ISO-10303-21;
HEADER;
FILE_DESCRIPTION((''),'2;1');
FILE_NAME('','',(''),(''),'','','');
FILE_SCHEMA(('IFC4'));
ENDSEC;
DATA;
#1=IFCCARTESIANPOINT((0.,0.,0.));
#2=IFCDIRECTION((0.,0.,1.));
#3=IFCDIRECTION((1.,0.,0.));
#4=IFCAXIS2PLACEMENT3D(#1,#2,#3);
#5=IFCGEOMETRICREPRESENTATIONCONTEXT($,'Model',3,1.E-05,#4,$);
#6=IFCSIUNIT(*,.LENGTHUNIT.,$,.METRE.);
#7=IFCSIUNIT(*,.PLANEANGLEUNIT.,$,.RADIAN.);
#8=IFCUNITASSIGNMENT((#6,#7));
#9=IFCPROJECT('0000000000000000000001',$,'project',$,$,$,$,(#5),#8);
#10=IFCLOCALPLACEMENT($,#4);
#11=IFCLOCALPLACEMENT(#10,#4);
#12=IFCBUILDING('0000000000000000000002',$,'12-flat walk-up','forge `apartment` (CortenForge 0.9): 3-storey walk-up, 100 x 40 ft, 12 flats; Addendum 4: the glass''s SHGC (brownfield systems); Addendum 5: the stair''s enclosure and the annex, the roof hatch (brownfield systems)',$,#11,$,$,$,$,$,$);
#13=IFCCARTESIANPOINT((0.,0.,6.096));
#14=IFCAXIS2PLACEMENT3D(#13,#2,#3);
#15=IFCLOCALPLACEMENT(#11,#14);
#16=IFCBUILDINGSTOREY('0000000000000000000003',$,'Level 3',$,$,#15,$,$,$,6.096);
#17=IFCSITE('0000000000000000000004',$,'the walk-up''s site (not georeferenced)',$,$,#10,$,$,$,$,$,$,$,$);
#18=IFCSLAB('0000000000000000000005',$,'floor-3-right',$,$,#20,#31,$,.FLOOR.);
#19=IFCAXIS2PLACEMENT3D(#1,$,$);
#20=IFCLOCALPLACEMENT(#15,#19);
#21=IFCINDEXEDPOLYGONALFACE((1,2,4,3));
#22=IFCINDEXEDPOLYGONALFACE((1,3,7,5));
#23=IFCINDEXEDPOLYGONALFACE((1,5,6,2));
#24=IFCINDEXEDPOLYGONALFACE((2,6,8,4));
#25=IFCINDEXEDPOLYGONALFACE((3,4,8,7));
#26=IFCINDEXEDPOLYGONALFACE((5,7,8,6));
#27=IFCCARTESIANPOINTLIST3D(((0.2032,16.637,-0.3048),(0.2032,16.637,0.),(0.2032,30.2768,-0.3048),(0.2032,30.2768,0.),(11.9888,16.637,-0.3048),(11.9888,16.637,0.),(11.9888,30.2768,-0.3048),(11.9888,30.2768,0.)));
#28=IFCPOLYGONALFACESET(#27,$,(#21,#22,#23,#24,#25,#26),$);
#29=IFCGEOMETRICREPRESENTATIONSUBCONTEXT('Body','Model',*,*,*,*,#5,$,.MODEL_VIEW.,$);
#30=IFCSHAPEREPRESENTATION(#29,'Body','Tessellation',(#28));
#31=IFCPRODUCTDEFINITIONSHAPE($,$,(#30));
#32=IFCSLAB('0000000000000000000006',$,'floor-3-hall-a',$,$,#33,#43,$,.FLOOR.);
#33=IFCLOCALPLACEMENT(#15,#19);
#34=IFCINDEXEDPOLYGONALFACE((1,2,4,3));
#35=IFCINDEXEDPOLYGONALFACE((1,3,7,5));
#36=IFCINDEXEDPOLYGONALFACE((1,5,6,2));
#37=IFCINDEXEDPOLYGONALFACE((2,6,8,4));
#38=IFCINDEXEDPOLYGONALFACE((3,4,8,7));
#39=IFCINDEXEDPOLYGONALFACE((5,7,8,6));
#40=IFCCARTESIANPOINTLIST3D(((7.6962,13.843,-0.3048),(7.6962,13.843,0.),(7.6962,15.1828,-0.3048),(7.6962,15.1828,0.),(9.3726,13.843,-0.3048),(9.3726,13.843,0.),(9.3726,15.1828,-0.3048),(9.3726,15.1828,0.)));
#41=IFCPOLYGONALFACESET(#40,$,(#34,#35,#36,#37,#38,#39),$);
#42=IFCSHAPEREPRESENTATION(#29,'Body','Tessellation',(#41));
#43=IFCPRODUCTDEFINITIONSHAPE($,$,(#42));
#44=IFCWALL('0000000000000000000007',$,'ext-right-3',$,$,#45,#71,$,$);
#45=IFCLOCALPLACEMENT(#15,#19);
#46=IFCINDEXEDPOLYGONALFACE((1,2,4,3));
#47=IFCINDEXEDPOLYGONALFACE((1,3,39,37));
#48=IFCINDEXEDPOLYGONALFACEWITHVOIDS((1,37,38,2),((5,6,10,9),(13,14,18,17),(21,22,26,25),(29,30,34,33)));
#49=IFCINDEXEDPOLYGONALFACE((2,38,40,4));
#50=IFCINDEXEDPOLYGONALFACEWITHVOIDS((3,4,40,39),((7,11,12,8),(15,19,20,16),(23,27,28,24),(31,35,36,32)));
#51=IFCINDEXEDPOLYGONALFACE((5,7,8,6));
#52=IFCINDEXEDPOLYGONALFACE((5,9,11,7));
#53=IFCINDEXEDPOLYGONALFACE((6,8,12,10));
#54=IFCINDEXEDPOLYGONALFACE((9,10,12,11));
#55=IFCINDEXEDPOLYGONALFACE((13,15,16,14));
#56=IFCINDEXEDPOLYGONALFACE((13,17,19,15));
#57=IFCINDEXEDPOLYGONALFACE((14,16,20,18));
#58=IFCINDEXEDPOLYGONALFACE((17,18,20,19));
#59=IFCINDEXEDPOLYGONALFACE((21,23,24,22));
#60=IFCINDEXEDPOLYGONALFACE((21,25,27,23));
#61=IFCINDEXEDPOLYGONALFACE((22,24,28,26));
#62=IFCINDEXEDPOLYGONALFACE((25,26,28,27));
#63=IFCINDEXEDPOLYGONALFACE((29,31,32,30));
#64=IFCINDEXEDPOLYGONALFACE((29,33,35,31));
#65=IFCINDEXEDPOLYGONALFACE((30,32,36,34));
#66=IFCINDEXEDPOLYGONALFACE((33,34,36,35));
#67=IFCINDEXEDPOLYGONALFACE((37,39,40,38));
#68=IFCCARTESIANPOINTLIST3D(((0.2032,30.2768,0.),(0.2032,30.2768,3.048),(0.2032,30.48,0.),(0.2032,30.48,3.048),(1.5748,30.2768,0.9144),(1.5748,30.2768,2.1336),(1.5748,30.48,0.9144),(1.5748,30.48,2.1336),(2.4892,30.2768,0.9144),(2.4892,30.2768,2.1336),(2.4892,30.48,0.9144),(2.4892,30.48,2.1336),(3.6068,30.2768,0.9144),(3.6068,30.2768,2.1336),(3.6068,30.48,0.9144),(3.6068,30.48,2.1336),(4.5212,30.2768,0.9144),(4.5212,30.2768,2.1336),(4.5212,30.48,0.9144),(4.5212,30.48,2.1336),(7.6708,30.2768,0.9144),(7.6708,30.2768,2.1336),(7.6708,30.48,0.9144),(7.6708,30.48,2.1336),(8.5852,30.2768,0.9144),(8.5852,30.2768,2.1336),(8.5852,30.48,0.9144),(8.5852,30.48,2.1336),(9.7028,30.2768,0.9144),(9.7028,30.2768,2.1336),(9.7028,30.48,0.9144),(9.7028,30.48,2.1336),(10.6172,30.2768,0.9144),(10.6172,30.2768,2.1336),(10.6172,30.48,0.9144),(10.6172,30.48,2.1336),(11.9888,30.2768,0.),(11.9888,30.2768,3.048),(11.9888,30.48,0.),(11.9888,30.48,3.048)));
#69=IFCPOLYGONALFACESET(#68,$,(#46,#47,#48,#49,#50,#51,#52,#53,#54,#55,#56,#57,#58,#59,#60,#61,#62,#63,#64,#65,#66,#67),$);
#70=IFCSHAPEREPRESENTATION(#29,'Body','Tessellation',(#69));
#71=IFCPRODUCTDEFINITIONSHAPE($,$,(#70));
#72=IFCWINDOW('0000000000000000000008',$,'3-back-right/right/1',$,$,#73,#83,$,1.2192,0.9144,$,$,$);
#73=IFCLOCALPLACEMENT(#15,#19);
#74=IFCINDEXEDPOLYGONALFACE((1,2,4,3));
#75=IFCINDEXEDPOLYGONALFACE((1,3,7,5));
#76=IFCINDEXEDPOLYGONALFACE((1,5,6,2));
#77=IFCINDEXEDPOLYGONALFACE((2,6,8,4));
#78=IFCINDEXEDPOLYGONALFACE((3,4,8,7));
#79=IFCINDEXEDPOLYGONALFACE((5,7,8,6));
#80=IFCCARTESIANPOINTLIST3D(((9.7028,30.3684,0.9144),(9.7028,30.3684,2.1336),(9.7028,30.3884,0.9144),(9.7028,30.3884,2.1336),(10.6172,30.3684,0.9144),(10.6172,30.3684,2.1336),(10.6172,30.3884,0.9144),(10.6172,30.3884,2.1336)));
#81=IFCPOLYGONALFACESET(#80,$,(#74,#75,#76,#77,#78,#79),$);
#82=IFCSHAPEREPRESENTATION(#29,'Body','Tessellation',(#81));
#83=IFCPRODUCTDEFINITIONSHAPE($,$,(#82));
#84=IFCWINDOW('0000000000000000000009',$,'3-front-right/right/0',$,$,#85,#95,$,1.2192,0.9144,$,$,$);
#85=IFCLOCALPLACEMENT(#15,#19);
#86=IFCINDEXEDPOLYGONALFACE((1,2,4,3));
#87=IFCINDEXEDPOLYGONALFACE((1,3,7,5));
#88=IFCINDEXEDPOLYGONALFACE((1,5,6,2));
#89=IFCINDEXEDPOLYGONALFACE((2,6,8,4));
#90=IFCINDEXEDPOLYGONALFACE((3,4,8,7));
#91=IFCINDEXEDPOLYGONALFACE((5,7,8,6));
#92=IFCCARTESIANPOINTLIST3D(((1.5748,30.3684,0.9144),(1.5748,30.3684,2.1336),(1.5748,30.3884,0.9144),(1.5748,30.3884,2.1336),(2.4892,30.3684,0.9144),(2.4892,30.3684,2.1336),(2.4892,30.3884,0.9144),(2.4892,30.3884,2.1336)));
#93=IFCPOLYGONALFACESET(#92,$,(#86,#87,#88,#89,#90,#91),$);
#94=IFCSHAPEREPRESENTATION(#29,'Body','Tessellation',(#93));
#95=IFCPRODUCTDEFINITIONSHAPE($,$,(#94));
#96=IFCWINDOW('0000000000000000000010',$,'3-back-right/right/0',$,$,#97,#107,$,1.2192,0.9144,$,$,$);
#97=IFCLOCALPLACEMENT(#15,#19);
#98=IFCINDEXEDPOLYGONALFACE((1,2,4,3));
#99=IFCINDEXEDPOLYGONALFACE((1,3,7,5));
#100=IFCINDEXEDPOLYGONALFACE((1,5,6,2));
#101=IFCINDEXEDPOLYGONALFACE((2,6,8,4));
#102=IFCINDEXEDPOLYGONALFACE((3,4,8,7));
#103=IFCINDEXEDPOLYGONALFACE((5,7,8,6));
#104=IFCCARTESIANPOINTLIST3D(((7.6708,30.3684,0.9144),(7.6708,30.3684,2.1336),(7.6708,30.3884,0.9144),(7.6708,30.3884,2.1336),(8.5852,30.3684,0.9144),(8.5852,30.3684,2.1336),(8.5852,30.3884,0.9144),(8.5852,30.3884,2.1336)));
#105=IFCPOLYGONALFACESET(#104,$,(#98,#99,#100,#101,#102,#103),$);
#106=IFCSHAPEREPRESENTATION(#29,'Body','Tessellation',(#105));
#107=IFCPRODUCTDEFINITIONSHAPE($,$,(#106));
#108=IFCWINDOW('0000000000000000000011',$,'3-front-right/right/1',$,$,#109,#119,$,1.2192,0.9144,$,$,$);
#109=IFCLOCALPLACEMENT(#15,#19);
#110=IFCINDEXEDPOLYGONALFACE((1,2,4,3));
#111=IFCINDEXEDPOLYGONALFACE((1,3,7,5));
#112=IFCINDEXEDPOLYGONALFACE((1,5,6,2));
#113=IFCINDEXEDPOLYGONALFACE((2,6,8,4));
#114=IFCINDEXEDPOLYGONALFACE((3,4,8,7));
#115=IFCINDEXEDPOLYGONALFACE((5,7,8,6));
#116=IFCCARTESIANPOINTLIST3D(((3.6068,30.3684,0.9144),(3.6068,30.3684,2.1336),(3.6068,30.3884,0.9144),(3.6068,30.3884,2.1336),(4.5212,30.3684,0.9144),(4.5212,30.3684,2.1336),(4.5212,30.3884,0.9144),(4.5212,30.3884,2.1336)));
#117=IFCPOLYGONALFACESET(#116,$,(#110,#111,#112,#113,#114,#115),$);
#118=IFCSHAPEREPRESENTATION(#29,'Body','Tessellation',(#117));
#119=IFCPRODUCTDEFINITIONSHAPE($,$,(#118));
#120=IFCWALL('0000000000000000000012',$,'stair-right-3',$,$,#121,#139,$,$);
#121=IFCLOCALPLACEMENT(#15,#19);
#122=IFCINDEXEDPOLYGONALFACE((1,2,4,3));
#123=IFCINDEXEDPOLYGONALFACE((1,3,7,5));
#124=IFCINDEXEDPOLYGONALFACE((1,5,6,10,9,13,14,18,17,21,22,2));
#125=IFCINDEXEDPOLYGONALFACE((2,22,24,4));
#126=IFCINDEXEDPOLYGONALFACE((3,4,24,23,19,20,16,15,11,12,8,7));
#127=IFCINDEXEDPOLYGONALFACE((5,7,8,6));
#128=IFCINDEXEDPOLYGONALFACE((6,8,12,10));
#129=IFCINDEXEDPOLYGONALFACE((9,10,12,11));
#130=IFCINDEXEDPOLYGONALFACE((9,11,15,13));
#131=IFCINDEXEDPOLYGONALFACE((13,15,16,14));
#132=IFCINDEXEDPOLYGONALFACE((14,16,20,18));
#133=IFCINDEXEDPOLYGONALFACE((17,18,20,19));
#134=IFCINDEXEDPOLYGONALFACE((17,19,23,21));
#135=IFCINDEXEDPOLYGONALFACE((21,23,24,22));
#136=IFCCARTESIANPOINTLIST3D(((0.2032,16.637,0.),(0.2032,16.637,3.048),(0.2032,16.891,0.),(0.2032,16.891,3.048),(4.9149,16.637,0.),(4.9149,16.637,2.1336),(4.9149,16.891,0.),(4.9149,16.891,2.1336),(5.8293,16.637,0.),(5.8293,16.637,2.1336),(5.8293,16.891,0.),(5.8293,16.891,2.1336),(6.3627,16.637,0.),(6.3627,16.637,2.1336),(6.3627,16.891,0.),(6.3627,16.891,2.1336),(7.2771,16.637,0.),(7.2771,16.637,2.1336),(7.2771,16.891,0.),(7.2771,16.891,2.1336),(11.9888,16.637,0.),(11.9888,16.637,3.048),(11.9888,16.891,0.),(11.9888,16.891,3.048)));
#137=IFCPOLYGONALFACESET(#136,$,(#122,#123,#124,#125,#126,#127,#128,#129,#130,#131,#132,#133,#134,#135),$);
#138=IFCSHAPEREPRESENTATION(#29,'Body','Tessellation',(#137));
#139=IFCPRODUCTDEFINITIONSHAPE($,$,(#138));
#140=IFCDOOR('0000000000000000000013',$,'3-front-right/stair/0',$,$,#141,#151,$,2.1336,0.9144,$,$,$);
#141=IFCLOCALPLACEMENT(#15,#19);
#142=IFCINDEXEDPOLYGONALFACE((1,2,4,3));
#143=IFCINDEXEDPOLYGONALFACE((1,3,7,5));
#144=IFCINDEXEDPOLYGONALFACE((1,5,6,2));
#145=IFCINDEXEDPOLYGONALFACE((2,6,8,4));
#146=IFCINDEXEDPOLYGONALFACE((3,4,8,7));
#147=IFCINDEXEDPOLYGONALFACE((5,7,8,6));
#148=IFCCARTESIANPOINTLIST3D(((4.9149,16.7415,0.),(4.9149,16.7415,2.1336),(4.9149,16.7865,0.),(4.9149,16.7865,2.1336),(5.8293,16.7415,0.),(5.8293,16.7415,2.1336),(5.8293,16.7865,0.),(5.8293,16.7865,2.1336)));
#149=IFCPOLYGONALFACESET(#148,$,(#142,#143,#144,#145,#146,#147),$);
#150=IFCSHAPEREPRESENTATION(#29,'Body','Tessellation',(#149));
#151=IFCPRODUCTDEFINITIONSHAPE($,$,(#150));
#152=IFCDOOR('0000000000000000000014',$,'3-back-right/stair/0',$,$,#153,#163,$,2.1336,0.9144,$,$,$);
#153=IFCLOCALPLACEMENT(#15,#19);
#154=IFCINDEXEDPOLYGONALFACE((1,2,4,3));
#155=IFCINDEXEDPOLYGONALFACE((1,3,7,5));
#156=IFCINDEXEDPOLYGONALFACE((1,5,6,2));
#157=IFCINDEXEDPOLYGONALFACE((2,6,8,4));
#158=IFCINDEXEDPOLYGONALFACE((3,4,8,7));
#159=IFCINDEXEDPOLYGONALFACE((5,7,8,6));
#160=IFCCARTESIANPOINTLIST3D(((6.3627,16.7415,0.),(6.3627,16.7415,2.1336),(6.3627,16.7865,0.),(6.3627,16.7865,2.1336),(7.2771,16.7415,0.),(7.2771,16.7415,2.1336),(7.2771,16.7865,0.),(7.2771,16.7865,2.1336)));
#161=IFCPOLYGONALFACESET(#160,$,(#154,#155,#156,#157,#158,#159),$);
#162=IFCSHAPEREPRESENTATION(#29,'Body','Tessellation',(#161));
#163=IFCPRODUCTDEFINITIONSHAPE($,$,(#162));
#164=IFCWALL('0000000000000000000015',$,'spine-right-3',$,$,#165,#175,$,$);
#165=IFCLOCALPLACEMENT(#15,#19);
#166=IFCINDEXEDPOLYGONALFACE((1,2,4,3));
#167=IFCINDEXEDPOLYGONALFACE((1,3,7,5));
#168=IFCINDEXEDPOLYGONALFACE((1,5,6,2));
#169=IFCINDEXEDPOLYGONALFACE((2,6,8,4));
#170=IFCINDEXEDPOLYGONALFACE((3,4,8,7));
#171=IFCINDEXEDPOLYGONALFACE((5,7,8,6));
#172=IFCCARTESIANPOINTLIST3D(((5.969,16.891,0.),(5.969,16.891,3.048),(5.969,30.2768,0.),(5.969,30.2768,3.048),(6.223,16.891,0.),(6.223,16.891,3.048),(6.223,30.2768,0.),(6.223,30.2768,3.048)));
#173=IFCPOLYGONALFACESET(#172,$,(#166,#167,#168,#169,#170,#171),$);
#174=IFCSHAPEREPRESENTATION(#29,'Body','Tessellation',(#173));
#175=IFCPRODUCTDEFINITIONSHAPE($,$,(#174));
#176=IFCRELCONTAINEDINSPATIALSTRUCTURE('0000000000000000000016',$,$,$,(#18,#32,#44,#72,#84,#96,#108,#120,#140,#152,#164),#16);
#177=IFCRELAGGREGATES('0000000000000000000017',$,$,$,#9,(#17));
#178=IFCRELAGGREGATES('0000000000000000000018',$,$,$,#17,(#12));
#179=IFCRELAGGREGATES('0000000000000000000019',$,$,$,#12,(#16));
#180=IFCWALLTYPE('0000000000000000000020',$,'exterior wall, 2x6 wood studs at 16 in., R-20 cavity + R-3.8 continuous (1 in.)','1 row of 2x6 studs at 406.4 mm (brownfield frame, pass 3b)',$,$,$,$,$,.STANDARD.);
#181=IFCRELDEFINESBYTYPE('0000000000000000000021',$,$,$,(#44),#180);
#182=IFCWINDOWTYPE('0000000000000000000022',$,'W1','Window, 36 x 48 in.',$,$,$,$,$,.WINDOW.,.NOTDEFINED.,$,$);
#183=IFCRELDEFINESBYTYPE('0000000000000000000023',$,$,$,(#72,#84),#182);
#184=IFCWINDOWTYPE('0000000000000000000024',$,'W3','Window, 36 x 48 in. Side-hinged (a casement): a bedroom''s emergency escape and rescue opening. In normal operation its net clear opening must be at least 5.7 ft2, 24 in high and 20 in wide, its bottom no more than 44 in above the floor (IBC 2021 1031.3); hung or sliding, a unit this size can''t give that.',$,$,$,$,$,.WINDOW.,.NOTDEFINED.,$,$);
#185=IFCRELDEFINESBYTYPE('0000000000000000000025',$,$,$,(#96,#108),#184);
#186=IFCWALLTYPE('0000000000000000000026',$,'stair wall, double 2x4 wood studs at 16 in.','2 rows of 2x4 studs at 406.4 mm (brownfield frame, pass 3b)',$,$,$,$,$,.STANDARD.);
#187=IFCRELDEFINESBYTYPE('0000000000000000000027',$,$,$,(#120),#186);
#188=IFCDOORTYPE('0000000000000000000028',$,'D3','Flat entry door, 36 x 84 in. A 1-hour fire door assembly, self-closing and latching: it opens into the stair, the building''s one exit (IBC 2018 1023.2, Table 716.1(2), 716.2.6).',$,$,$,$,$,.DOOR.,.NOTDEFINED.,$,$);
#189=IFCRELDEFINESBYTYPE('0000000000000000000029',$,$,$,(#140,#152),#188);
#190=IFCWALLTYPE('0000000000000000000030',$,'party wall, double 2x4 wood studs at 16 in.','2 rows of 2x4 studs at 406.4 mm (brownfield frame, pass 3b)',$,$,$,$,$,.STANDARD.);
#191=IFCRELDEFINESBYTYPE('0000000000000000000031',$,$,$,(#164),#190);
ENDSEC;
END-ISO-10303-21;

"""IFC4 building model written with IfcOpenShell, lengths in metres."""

from ifc_helpers import new_model, si_unit, frame, frame_2d, origin, origin_with_axes, place, context, subcontext, project, spatial, rectangle, extrude, type_object, element, fill, save


model = new_model("IFC4")

# Units and contexts
model_context = context("Model", 3, precision=1e-05, world=origin_with_axes())
body_context = subcontext(model_context, "Body", "Model", "MODEL_VIEW")
ifc_project = project(units=[si_unit("LENGTHUNIT", "METRE"), si_unit("PLANEANGLEUNIT", "RADIAN")], contexts=[model_context])

# Site, building, storey
site_placement = place(None, origin_with_axes())
site = spatial("IfcSite", under=ifc_project, at=site_placement, Name="the walk-up's site (not georeferenced)")
building_placement = place(site_placement, origin_with_axes())
building = spatial("IfcBuilding", under=site, at=building_placement, Name="12-flat walk-up", Description="forge `apartment` (CortenForge 0.9): 3-storey walk-up, 100 x 40 ft, 12 flats; Addendum 4: the glass's SHGC (brownfield systems); Addendum 5: the stair's enclosure and the annex, the roof hatch (brownfield systems)")
storey_placement = place(building_placement, frame((0.0, 0.0, 6.096), z_axis=(0.0, 0.0, 1.0), x_axis=(1.0, 0.0, 0.0)))
storey = spatial("IfcBuildingStorey", under=building, at=storey_placement, Name="Level 3", Elevation=6.096)

# Slabs
slab_1_placement = place(storey_placement, frame((0.2032, 16.637, -0.3048), z_axis=(0.0, 0.0, 1.0), x_axis=(1.0, 0.0, 0.0)))
element("IfcSlab", 1, at=slab_1_placement, inside=storey, Name="floor-3-right", PredefinedType="FLOOR", context=body_context, shape_type="SweptSolid", body=[
    extrude(rectangle(XDim=11.7856, YDim=13.6398, at=frame_2d((5.8928, 6.8199))), origin(), (0.0, 0.0, 1.0), 0.3048),
])
slab_2_placement = place(storey_placement, frame((7.6962, 13.843, -0.3048), z_axis=(0.0, 0.0, 1.0), x_axis=(1.0, 0.0, 0.0)))
element("IfcSlab", 2, at=slab_2_placement, inside=storey, Name="floor-3-hall-a", PredefinedType="FLOOR", context=body_context, shape_type="SweptSolid", body=[
    extrude(rectangle(XDim=1.6764, YDim=1.3399, at=frame_2d((0.8382, 0.6699))), origin(), (0.0, 0.0, 1.0), 0.3048),
])

# Wall, openings, windows
wall_type_1 = type_object("IfcWallType", Name="exterior wall, 2x6 wood studs at 16 in., R-20 cavity + R-3.8 continuous (1 in.)", Description="1 row of 2x6 studs at 406.4 mm (brownfield frame, pass 3b)", PredefinedType="STANDARD")
wall_1_placement = place(storey_placement, frame((0.2032, 30.2768, 0.0), z_axis=(0.0, 0.0, 1.0), x_axis=(1.0, 0.0, 0.0)))
wall_1 = element("IfcWall", 3, at=wall_1_placement, inside=storey, type_object=wall_type_1, Name="ext-right-3", context=body_context, shape_type="SweptSolid", body=[
    extrude(rectangle(XDim=11.7856, YDim=0.2032, at=frame_2d((5.8928, 0.1016))), origin(), (0.0, 0.0, 1.0), 3.048),
])
opening_1_placement = place(wall_1_placement, frame((8.382, 0.2032, 0.9144), z_axis=(0.0, 0.0, 1.0), x_axis=(-1.0, 0.0, 0.0)))
opening_1 = element("IfcOpeningElement", 4, at=opening_1_placement, cuts=wall_1, PredefinedType="OPENING", context=body_context, shape_type="SweptSolid", body=[
    extrude(rectangle(XDim=0.9144, YDim=0.2032, at=frame_2d((0.4572, 0.1016))), origin(), (0.0, 0.0, 1.0), 1.2192),
])
opening_2_placement = place(wall_1_placement, frame((10.414, 0.2032, 0.9144), z_axis=(0.0, 0.0, 1.0), x_axis=(-1.0, 0.0, 0.0)))
opening_2 = element("IfcOpeningElement", 5, at=opening_2_placement, cuts=wall_1, PredefinedType="OPENING", context=body_context, shape_type="SweptSolid", body=[
    extrude(rectangle(XDim=0.9144, YDim=0.2032, at=frame_2d((0.4572, 0.1016))), origin(), (0.0, 0.0, 1.0), 1.2192),
])
opening_3_placement = place(wall_1_placement, frame((2.286, 0.2032, 0.9144), z_axis=(0.0, 0.0, 1.0), x_axis=(-1.0, 0.0, 0.0)))
opening_3 = element("IfcOpeningElement", 6, at=opening_3_placement, cuts=wall_1, PredefinedType="OPENING", context=body_context, shape_type="SweptSolid", body=[
    extrude(rectangle(XDim=0.9144, YDim=0.2032, at=frame_2d((0.4572, 0.1016))), origin(), (0.0, 0.0, 1.0), 1.2192),
])
opening_4_placement = place(wall_1_placement, frame((4.318, 0.2032, 0.9144), z_axis=(0.0, 0.0, 1.0), x_axis=(-1.0, 0.0, 0.0)))
opening_4 = element("IfcOpeningElement", 7, at=opening_4_placement, cuts=wall_1, PredefinedType="OPENING", context=body_context, shape_type="SweptSolid", body=[
    extrude(rectangle(XDim=0.9144, YDim=0.2032, at=frame_2d((0.4572, 0.1016))), origin(), (0.0, 0.0, 1.0), 1.2192),
])
window_type_1 = type_object("IfcWindowType", Name="W1", Description="Window, 36 x 48 in.", PartitioningType="NOTDEFINED", PredefinedType="WINDOW")
window_1_placement = place(opening_2_placement, frame((0.0, 0.0916, 0.0), z_axis=(0.0, 0.0, 1.0), x_axis=(1.0, 0.0, 0.0)))
window_1 = element("IfcWindow", 8, at=window_1_placement, inside=storey, type_object=window_type_1, Name="3-back-right/right/1", OverallHeight=1.2192, OverallWidth=0.9144, context=body_context, shape_type="SweptSolid", body=[
    extrude(rectangle(XDim=0.9144, YDim=0.02, at=frame_2d((0.4572, 0.01))), origin(), (0.0, 0.0, 1.0), 1.2192),
])
fill(opening_2, window_1)
window_2_placement = place(opening_3_placement, frame((0.0, 0.0916, 0.0), z_axis=(0.0, 0.0, 1.0), x_axis=(1.0, 0.0, 0.0)))
window_2 = element("IfcWindow", 9, at=window_2_placement, inside=storey, type_object=window_type_1, Name="3-front-right/right/0", OverallHeight=1.2192, OverallWidth=0.9144, context=body_context, shape_type="SweptSolid", body=[
    extrude(rectangle(XDim=0.9144, YDim=0.02, at=frame_2d((0.4572, 0.01))), origin(), (0.0, 0.0, 1.0), 1.2192),
])
fill(opening_3, window_2)
window_type_2 = type_object("IfcWindowType", Name="W3", Description="Window, 36 x 48 in. Side-hinged (a casement): a bedroom's emergency escape and rescue opening. In normal operation its net clear opening must be at least 5.7 ft2, 24 in high and 20 in wide, its bottom no more than 44 in above the floor (IBC 2021 1031.3); hung or sliding, a unit this size can't give that.", PartitioningType="NOTDEFINED", PredefinedType="WINDOW")
window_3_placement = place(opening_1_placement, frame((0.0, 0.0916, 0.0), z_axis=(0.0, 0.0, 1.0), x_axis=(1.0, 0.0, 0.0)))
window_3 = element("IfcWindow", 10, at=window_3_placement, inside=storey, type_object=window_type_2, Name="3-back-right/right/0", OverallHeight=1.2192, OverallWidth=0.9144, context=body_context, shape_type="SweptSolid", body=[
    extrude(rectangle(XDim=0.9144, YDim=0.02, at=frame_2d((0.4572, 0.01))), origin(), (0.0, 0.0, 1.0), 1.2192),
])
fill(opening_1, window_3)
window_4_placement = place(opening_4_placement, frame((0.0, 0.0916, 0.0), z_axis=(0.0, 0.0, 1.0), x_axis=(1.0, 0.0, 0.0)))
window_4 = element("IfcWindow", 11, at=window_4_placement, inside=storey, type_object=window_type_2, Name="3-front-right/right/1", OverallHeight=1.2192, OverallWidth=0.9144, context=body_context, shape_type="SweptSolid", body=[
    extrude(rectangle(XDim=0.9144, YDim=0.02, at=frame_2d((0.4572, 0.01))), origin(), (0.0, 0.0, 1.0), 1.2192),
])
fill(opening_4, window_4)

# Wall, openings, doors
wall_type_2 = type_object("IfcWallType", Name="stair wall, double 2x4 wood studs at 16 in.", Description="2 rows of 2x4 studs at 406.4 mm (brownfield frame, pass 3b)", PredefinedType="STANDARD")
wall_2_placement = place(storey_placement, frame((0.2032, 16.637, 0.0), z_axis=(0.0, 0.0, 1.0), x_axis=(1.0, 0.0, 0.0)))
wall_2 = element("IfcWall", 12, at=wall_2_placement, inside=storey, type_object=wall_type_2, Name="stair-right-3", context=body_context, shape_type="SweptSolid", body=[
    extrude(rectangle(XDim=11.7856, YDim=0.254, at=frame_2d((5.8928, 0.127))), origin(), (0.0, 0.0, 1.0), 3.048),
])
opening_5_placement = place(wall_2_placement, frame((5.6261, 0.254, 0.0), z_axis=(0.0, 0.0, 1.0), x_axis=(-1.0, 0.0, 0.0)))
opening_5 = element("IfcOpeningElement", 13, at=opening_5_placement, cuts=wall_2, PredefinedType="OPENING", context=body_context, shape_type="SweptSolid", body=[
    extrude(rectangle(XDim=0.9144, YDim=0.254, at=frame_2d((0.4572, 0.127))), origin(), (0.0, 0.0, 1.0), 2.1336),
])
opening_6_placement = place(wall_2_placement, frame((7.0739, 0.254, 0.0), z_axis=(0.0, 0.0, 1.0), x_axis=(-1.0, 0.0, 0.0)))
opening_6 = element("IfcOpeningElement", 14, at=opening_6_placement, cuts=wall_2, PredefinedType="OPENING", context=body_context, shape_type="SweptSolid", body=[
    extrude(rectangle(XDim=0.9144, YDim=0.254, at=frame_2d((0.4572, 0.127))), origin(), (0.0, 0.0, 1.0), 2.1336),
])
door_type = type_object("IfcDoorType", Name="D3", Description="Flat entry door, 36 x 84 in. A 1-hour fire door assembly, self-closing and latching: it opens into the stair, the building's one exit (IBC 2018 1023.2, Table 716.1(2), 716.2.6).", OperationType="NOTDEFINED", PredefinedType="DOOR")
door_1_placement = place(opening_5_placement, frame((0.0, 0.1045, 0.0), z_axis=(0.0, 0.0, 1.0), x_axis=(1.0, 0.0, 0.0)))
door_1 = element("IfcDoor", 15, at=door_1_placement, inside=storey, type_object=door_type, Name="3-front-right/stair/0", OverallHeight=2.1336, OverallWidth=0.9144, context=body_context, shape_type="SweptSolid", body=[
    extrude(rectangle(XDim=0.9144, YDim=0.045, at=frame_2d((0.4572, 0.0225))), origin(), (0.0, 0.0, 1.0), 2.1336),
])
fill(opening_5, door_1)
door_2_placement = place(opening_6_placement, frame((0.0, 0.1045, 0.0), z_axis=(0.0, 0.0, 1.0), x_axis=(1.0, 0.0, 0.0)))
door_2 = element("IfcDoor", 16, at=door_2_placement, inside=storey, type_object=door_type, Name="3-back-right/stair/0", OverallHeight=2.1336, OverallWidth=0.9144, context=body_context, shape_type="SweptSolid", body=[
    extrude(rectangle(XDim=0.9144, YDim=0.045, at=frame_2d((0.4572, 0.0225))), origin(), (0.0, 0.0, 1.0), 2.1336),
])
fill(opening_6, door_2)

# Wall
wall_type_3 = type_object("IfcWallType", Name="party wall, double 2x4 wood studs at 16 in.", Description="2 rows of 2x4 studs at 406.4 mm (brownfield frame, pass 3b)", PredefinedType="STANDARD")
wall_3_placement = place(storey_placement, frame((5.969, 16.891, 0.0), z_axis=(0.0, 0.0, 1.0), x_axis=(1.0, 0.0, 0.0)))
element("IfcWall", 17, at=wall_3_placement, inside=storey, type_object=wall_type_3, Name="spine-right-3", context=body_context, shape_type="SweptSolid", body=[
    extrude(rectangle(XDim=0.254, YDim=13.3858, at=frame_2d((0.127, 6.6929))), origin(), (0.0, 0.0, 1.0), 3.048),
])

save(model, "model.ifc")
